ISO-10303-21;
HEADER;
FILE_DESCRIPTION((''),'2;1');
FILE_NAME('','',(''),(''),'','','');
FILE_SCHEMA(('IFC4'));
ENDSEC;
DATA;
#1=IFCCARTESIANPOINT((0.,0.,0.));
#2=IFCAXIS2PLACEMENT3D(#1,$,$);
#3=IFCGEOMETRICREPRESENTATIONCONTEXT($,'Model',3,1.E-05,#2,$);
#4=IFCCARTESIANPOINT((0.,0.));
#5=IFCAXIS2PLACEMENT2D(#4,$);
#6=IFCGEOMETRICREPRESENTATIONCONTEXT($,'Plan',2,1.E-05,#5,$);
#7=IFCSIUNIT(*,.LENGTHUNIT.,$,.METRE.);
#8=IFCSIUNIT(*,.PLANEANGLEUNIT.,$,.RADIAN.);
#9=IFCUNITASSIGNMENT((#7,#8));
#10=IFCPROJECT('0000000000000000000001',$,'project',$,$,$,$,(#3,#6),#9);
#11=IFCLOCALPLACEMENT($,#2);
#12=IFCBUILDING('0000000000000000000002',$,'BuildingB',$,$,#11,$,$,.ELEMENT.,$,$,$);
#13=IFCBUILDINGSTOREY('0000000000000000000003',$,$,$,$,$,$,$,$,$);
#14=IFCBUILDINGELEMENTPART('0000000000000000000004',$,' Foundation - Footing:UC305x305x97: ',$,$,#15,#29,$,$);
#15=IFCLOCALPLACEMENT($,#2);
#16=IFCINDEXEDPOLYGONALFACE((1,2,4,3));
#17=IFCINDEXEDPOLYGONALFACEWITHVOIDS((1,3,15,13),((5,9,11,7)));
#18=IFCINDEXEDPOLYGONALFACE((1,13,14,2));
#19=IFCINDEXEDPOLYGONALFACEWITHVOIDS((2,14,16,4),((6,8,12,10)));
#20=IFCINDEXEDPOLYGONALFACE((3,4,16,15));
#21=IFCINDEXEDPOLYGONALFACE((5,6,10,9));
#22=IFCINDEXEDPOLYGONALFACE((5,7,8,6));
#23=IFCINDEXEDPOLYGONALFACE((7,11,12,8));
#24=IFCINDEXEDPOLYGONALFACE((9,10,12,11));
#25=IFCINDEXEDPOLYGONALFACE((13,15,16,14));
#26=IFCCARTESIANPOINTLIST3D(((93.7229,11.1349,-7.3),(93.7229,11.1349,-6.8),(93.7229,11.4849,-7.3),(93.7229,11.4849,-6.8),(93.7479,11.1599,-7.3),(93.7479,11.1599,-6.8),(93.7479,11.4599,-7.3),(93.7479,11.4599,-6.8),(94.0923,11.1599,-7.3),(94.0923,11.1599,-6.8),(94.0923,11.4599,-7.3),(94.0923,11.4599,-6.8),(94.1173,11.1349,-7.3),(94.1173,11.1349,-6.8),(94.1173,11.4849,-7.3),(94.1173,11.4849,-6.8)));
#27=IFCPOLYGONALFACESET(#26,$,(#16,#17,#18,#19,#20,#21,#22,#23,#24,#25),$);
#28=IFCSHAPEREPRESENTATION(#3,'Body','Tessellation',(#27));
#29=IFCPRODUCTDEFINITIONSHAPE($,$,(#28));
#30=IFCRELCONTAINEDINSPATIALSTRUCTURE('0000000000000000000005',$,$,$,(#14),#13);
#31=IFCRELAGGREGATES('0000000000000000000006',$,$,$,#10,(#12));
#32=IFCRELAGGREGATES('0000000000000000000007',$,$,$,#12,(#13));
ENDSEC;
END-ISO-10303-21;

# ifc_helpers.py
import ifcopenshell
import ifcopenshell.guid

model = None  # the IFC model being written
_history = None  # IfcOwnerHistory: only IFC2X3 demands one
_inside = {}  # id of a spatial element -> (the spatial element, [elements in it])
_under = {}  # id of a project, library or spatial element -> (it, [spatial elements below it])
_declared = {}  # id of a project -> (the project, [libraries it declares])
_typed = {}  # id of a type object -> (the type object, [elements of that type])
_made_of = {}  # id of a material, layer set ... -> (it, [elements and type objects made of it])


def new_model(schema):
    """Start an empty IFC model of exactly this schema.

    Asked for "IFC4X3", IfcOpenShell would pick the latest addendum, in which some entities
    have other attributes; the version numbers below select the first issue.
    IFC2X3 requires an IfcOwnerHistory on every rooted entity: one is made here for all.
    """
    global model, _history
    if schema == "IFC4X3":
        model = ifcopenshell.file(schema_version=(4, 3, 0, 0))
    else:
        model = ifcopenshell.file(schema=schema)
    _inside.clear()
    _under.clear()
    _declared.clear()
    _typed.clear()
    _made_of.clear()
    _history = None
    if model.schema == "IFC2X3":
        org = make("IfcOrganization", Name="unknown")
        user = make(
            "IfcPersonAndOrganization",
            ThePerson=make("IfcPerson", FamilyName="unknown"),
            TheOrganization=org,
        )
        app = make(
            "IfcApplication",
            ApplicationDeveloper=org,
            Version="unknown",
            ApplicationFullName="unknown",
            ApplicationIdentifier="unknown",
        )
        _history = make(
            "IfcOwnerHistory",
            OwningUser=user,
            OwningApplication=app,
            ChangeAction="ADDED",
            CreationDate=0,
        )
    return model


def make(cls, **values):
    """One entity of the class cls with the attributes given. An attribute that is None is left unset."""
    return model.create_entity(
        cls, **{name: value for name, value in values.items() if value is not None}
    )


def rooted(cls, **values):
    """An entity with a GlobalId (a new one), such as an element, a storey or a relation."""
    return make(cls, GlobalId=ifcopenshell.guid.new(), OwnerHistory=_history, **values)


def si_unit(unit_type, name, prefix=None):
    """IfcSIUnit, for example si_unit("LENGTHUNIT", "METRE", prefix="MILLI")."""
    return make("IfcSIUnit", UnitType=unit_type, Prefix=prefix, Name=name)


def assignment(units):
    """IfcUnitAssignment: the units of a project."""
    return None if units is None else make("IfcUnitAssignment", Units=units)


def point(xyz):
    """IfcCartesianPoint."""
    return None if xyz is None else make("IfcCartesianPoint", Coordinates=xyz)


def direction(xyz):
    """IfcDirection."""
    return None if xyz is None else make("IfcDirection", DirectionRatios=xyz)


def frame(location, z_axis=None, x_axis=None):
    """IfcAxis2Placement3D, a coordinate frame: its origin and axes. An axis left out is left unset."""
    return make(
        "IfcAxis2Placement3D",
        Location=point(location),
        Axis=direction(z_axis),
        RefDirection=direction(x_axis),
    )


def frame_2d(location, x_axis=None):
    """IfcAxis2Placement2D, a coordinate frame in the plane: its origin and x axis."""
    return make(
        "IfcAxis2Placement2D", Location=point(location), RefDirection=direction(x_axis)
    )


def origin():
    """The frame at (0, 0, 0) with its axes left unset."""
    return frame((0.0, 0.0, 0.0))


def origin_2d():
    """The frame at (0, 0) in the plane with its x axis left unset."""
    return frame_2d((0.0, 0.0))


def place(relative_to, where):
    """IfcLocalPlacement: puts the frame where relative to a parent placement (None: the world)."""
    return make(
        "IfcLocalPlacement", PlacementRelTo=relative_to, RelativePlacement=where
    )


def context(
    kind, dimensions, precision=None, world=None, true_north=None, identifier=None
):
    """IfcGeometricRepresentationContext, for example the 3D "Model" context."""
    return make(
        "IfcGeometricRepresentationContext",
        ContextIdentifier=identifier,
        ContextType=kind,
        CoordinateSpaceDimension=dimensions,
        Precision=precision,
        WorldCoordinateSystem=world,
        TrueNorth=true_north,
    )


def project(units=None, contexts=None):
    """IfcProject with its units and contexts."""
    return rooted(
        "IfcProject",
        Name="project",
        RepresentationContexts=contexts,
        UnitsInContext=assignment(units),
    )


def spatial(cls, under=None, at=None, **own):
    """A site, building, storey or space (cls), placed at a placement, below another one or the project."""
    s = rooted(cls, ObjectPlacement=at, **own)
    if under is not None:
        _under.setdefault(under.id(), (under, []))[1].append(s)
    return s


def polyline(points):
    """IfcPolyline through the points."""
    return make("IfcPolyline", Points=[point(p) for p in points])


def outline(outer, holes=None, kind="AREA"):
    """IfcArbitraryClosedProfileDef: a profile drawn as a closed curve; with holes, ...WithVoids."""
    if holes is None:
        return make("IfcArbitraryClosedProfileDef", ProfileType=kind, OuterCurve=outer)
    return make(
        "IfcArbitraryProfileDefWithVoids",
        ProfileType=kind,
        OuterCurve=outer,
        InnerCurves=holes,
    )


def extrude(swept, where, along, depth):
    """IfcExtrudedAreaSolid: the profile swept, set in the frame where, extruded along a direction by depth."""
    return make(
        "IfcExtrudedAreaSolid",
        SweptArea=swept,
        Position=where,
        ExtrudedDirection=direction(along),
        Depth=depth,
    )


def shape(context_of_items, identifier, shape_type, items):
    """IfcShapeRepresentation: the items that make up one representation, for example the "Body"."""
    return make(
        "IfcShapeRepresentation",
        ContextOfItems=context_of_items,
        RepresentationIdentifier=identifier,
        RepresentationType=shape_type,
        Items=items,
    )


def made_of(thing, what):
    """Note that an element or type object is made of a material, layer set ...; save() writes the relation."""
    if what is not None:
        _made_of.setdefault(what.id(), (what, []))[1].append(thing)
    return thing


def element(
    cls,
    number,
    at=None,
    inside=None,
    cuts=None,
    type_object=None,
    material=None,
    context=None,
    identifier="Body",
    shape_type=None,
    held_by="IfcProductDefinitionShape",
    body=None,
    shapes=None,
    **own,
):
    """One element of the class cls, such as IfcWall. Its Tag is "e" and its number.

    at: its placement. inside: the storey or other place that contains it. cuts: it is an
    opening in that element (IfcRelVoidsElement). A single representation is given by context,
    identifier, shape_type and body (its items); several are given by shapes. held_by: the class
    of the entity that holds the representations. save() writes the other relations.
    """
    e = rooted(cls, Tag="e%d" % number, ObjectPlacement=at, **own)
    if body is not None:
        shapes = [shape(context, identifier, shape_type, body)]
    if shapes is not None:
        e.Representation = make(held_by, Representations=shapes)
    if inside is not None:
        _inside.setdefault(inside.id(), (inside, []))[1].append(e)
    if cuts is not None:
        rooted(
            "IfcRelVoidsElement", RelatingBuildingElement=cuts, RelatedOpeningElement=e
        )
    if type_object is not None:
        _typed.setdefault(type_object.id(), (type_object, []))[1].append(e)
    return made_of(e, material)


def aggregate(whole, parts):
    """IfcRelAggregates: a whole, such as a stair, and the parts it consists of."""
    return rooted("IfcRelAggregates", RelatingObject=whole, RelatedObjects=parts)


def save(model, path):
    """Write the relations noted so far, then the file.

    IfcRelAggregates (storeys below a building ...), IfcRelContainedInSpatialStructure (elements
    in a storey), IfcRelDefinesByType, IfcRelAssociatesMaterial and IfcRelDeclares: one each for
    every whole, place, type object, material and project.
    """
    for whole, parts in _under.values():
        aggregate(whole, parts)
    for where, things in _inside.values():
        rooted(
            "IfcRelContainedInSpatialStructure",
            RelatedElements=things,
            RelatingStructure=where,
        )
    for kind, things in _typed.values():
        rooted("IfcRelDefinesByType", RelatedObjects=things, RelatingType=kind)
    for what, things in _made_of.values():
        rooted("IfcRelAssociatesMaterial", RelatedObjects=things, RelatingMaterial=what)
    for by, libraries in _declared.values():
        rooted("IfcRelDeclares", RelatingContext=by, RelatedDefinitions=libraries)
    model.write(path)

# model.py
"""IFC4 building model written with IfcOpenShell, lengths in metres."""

from ifc_helpers import new_model, si_unit, origin, origin_2d, place, context, project, spatial, polyline, outline, extrude, element, save


model = new_model("IFC4")

# Units and contexts
model_context = context("Model", 3, precision=1e-05, world=origin())
plan_context = context("Plan", 2, precision=1e-05, world=origin_2d())
ifc_project = project(units=[si_unit("LENGTHUNIT", "METRE"), si_unit("PLANEANGLEUNIT", "RADIAN")], contexts=[model_context, plan_context])

# Building, storey
building_placement = place(None, origin())
building = spatial("IfcBuilding", under=ifc_project, at=building_placement, Name="BuildingB", CompositionType="ELEMENT")
storey = spatial("IfcBuildingStorey", under=building)

# Building element part, opening
building_element_part_1 = element("IfcBuildingElementPart", 1, inside=storey, Name=" Foundation - Footing:UC305x305x97: ", context=model_context, shape_type="SweptSolid", body=[
    extrude(outline(polyline([(94.1173, 11.1349, -7.3), (93.7229, 11.1349, -7.3), (93.7229, 11.4849, -7.3), (94.1173, 11.4849, -7.3), (94.1173, 11.1349, -7.3)])), None, (0.0, 0.0, 1.0), 0.5),
])
element("IfcOpeningElement", 2, inside=storey, cuts=building_element_part_1, context=model_context, shape_type="SweptSolid", body=[
    extrude(outline(polyline([(94.0923, 11.1599, -7.3), (93.7479, 11.1599, -7.3), (93.7479, 11.4599, -7.3), (94.0923, 11.4599, -7.3), (94.0923, 11.1599, -7.3)])), None, (0.0, 0.0, 1.0), 0.5),
])

save(model, "model.ifc")
